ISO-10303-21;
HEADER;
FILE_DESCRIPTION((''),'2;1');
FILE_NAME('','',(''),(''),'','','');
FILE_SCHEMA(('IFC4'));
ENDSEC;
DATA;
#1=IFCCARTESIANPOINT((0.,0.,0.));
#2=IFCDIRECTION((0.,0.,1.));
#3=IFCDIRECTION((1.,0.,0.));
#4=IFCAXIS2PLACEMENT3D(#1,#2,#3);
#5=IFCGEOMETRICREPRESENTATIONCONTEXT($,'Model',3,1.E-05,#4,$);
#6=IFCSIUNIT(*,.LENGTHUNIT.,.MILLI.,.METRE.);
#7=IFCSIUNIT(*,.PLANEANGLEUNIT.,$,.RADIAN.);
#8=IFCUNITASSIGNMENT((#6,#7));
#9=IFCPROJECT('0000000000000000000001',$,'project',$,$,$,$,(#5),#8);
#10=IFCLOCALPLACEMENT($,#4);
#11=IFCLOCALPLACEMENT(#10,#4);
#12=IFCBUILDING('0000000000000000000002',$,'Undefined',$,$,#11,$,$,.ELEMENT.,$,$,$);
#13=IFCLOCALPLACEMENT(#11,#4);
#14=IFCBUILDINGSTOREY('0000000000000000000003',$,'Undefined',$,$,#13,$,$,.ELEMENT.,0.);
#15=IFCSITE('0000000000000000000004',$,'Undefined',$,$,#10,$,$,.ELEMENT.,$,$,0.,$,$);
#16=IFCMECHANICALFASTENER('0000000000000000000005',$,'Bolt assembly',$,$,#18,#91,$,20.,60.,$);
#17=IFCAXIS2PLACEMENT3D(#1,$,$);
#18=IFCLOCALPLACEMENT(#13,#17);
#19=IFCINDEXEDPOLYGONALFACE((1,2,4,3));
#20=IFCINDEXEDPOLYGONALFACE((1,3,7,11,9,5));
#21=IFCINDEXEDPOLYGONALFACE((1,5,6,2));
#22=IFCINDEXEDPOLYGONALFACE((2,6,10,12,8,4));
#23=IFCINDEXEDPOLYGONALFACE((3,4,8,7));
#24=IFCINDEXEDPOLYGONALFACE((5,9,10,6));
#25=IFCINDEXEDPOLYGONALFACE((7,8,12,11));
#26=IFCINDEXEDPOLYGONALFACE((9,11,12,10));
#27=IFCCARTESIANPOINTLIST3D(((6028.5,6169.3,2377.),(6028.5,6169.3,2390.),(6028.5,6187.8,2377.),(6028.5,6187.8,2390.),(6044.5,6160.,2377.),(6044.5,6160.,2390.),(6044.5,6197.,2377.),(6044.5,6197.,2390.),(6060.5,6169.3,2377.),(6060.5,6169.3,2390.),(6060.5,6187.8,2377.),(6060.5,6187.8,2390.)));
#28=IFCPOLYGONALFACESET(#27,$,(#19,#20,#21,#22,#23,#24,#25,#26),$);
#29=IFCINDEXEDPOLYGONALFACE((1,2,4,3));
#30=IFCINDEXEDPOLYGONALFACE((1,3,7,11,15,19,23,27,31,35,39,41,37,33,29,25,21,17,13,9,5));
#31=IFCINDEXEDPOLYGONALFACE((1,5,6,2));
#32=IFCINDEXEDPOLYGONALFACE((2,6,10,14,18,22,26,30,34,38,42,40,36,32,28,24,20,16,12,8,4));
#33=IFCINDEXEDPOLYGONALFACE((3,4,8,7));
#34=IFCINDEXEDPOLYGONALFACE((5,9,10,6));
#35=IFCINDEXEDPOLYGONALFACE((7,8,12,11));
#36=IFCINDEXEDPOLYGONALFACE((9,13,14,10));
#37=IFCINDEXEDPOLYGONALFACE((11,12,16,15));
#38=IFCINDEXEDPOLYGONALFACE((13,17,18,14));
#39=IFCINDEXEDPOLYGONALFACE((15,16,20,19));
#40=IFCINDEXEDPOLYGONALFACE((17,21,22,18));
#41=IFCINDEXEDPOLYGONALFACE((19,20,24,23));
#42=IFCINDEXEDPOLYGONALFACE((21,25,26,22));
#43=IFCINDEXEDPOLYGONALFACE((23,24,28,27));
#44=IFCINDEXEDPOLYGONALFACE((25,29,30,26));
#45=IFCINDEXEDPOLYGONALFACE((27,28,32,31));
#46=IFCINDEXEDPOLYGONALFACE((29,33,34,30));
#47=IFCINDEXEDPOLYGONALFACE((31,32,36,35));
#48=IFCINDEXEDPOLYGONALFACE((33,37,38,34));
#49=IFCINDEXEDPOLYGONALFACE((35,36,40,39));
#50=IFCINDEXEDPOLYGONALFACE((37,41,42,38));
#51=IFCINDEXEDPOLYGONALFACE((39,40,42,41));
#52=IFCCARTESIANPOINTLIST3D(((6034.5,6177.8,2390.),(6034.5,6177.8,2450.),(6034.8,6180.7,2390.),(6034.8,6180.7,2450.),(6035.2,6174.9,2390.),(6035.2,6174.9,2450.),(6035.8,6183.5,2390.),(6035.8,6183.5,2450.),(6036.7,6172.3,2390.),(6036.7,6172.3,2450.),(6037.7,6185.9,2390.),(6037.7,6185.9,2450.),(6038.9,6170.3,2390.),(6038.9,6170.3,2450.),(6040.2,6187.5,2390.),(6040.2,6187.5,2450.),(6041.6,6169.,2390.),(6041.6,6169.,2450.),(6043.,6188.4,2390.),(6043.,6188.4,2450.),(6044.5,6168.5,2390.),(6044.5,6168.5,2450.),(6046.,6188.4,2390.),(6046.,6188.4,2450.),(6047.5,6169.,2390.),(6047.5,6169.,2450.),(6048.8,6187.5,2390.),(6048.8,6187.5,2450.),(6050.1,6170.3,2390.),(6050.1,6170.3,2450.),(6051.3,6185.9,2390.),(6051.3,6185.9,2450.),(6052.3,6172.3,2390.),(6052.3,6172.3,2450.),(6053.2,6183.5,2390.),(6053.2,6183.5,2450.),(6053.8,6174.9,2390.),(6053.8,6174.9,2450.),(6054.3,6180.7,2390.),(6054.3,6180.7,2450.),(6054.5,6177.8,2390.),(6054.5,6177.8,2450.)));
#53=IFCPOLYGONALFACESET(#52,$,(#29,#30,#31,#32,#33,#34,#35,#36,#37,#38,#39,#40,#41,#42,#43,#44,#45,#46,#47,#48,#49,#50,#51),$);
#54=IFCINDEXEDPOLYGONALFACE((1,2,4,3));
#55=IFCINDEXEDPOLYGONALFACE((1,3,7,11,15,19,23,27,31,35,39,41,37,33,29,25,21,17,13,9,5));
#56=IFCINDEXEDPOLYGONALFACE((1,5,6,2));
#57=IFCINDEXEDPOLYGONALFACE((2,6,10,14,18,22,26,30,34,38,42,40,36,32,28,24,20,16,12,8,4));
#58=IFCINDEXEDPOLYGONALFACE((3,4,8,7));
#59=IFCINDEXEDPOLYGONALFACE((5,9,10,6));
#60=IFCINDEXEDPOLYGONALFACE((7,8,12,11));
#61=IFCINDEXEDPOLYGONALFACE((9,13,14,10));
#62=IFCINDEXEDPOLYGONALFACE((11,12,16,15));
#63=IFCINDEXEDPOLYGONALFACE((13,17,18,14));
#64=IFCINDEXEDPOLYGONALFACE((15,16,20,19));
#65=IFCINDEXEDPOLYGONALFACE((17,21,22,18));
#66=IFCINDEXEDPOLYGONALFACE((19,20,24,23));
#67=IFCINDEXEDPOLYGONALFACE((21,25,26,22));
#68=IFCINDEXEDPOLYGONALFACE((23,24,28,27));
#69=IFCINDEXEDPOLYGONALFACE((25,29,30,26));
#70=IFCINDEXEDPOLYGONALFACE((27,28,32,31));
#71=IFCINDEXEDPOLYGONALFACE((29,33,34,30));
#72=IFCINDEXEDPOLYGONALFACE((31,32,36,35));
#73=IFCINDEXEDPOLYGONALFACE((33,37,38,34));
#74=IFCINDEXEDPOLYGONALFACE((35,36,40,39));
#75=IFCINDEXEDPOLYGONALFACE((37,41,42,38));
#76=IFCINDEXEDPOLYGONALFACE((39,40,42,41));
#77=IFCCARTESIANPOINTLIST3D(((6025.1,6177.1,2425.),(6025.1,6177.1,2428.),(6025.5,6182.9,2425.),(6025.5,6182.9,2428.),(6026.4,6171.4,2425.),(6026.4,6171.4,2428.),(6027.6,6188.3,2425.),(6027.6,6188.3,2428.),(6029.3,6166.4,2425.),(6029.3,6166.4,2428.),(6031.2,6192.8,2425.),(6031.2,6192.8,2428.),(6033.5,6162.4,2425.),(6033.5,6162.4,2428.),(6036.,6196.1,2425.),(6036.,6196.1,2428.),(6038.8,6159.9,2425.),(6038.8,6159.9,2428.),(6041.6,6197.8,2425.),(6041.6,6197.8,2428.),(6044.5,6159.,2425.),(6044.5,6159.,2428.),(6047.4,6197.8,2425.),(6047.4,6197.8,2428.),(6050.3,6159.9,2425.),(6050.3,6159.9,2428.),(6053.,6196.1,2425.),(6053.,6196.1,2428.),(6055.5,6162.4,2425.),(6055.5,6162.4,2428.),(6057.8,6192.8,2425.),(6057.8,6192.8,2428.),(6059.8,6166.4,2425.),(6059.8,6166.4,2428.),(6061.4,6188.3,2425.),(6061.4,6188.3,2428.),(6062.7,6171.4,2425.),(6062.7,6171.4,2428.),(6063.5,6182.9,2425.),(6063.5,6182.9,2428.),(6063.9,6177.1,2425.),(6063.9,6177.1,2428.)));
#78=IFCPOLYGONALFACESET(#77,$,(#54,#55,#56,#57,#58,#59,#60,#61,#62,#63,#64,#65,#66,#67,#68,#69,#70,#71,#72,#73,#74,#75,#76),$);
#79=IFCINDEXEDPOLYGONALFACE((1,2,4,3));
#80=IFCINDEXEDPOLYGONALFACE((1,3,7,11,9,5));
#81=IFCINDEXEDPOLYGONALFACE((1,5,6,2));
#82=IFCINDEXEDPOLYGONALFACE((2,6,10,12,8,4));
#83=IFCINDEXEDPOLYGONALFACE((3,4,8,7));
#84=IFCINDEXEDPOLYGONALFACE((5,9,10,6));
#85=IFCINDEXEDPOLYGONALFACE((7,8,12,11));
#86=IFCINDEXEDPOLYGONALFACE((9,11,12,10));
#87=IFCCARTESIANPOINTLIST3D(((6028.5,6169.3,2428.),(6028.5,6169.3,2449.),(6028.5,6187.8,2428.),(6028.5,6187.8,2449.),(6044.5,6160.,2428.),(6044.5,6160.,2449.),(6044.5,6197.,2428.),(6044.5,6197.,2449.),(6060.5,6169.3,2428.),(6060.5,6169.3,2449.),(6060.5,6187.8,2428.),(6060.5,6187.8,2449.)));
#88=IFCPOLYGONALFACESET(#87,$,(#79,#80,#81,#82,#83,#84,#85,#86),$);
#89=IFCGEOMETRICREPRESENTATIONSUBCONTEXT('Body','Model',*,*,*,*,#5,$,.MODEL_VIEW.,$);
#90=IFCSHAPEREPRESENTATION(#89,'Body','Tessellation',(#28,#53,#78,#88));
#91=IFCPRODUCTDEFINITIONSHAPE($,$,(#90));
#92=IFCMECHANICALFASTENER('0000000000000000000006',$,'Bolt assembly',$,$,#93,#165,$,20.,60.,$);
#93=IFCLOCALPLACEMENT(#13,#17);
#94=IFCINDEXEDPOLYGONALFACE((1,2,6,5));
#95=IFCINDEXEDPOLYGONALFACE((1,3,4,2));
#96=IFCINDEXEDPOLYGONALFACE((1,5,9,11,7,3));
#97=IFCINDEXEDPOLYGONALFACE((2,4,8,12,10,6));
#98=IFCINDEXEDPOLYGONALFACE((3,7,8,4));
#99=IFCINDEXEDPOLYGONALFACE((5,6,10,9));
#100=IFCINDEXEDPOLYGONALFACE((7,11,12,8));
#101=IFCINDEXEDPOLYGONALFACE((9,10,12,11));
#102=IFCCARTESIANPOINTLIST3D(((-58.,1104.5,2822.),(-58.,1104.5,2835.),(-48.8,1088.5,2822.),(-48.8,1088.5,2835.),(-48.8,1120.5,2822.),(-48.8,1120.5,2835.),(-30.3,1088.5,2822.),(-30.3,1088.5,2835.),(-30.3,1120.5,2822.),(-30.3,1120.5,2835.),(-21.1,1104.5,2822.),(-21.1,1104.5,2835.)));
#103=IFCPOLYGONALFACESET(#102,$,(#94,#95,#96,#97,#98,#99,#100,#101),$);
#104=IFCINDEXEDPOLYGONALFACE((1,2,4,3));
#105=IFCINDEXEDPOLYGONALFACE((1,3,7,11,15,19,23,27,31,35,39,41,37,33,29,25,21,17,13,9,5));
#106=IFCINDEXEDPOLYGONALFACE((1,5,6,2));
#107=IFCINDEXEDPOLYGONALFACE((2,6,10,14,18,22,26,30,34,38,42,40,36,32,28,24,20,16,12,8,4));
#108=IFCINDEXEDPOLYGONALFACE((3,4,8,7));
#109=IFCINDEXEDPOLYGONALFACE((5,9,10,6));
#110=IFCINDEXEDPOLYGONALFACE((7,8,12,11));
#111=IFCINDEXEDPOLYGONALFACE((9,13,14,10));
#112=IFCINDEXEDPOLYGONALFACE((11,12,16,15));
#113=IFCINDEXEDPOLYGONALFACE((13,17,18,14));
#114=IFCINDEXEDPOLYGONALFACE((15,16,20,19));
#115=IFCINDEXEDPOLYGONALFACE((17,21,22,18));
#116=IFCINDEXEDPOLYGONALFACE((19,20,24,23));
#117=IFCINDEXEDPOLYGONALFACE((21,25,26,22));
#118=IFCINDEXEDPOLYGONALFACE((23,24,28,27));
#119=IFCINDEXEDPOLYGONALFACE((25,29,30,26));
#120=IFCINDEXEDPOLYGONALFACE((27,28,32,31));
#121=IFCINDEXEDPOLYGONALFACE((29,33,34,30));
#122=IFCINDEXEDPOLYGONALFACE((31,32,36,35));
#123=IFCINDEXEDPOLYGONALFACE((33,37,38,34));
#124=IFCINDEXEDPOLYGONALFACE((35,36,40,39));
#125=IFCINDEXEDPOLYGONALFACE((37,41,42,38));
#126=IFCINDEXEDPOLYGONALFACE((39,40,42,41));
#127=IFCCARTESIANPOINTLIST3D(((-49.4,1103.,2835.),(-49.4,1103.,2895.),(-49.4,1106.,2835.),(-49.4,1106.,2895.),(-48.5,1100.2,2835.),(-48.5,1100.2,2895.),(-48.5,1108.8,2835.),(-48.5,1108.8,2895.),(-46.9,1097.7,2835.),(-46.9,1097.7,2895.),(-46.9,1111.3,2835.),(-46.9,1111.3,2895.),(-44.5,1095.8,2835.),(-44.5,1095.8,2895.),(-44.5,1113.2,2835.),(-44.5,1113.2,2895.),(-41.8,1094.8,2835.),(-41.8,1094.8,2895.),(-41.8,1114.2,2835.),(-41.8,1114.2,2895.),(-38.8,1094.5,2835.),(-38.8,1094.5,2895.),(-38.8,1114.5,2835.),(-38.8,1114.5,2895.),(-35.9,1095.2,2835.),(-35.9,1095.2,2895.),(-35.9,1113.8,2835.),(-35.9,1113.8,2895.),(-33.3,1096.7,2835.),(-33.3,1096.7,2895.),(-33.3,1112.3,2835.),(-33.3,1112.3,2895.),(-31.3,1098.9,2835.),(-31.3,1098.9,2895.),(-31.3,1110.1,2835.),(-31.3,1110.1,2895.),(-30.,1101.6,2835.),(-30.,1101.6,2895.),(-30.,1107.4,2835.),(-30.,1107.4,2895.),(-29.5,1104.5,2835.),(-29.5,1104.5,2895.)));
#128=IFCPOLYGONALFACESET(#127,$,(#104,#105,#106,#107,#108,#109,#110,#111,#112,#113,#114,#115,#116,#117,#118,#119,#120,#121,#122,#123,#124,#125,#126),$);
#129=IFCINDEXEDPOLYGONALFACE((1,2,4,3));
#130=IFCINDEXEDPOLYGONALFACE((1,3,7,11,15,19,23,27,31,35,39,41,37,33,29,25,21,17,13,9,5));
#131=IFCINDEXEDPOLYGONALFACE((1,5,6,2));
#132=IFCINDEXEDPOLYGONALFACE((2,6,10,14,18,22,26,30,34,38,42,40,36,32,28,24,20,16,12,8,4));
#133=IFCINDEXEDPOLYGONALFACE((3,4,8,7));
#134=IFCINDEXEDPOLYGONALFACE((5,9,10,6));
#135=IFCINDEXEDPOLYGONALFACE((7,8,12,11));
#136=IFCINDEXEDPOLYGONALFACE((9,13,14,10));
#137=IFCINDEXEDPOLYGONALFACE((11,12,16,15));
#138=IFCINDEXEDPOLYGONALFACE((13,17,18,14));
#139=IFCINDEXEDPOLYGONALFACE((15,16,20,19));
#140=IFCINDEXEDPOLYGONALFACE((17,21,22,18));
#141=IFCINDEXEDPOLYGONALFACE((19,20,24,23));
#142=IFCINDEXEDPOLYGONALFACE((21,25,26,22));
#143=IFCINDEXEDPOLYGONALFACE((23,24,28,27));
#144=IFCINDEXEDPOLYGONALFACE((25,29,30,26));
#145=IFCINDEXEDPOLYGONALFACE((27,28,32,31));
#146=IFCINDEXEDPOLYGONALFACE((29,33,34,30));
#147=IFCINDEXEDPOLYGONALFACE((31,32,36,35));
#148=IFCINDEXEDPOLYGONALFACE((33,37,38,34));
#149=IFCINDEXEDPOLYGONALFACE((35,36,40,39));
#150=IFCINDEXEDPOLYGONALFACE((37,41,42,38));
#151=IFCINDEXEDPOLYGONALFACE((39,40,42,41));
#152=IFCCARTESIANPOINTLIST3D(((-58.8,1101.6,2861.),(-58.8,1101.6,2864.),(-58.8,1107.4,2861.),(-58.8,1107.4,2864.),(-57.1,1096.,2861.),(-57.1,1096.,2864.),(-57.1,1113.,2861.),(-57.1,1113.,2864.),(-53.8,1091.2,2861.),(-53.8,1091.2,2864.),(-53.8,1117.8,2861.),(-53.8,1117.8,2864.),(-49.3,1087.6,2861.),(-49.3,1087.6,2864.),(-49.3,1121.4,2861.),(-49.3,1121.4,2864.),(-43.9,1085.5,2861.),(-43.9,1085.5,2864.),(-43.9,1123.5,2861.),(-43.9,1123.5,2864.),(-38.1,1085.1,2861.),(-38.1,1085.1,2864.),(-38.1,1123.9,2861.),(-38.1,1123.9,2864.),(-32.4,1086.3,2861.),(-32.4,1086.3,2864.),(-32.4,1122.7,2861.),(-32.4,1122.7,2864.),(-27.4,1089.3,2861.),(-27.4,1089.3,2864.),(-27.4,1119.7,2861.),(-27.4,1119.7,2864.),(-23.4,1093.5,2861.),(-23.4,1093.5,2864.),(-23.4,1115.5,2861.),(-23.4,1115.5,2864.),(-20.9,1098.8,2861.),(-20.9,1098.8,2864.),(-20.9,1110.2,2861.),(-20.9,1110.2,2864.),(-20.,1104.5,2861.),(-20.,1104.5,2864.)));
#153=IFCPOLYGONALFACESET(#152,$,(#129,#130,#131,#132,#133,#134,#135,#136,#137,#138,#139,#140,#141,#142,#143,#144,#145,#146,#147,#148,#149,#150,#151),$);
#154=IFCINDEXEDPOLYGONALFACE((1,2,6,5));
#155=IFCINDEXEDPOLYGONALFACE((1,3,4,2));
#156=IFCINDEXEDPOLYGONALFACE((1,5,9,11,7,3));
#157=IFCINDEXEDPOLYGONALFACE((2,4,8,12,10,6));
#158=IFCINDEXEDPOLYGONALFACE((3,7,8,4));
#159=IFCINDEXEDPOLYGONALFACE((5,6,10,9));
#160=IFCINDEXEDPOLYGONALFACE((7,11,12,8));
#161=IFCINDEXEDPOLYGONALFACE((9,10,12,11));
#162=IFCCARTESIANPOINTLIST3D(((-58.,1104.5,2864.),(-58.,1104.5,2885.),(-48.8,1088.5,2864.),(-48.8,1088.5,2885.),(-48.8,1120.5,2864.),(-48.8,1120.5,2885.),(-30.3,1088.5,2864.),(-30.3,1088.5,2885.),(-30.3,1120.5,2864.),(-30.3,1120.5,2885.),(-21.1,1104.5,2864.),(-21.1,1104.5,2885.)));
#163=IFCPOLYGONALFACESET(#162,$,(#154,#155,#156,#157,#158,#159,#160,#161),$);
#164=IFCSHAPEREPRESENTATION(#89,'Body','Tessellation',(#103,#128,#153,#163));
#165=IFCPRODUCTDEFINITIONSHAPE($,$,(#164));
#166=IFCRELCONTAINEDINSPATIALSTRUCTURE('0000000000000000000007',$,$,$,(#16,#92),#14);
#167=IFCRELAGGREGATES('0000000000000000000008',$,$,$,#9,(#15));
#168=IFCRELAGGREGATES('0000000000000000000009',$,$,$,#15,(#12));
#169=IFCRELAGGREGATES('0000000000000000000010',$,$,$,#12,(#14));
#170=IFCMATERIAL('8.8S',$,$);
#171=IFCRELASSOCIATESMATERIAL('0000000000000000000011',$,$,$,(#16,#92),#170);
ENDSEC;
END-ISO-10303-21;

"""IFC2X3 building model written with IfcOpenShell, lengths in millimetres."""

from ifc_helpers import new_model, si_unit, frame, origin_with_axes, origin_2d_with_axis, place, context, subcontext, project, spatial, polyline, circle, outline, extrude, source, transform, mapped, material, element, save


model = new_model("IFC2X3")

# Units and contexts
model_context = context("Model", 3, precision=1e-05, world=origin_with_axes())
body_context = subcontext(model_context, "Body", "Model", "MODEL_VIEW")
ifc_project = project(units=[si_unit("LENGTHUNIT", "METRE", prefix="MILLI"), si_unit("PLANEANGLEUNIT", "RADIAN")], contexts=[model_context])

# Site, building, storey
site_placement = place(None, origin_with_axes())
site = spatial("IfcSite", under=ifc_project, at=site_placement, Name="Undefined", CompositionType="ELEMENT", RefElevation=0.0)
building_placement = place(site_placement, origin_with_axes())
building = spatial("IfcBuilding", under=site, at=building_placement, Name="Undefined", CompositionType="ELEMENT")
storey_placement = place(building_placement, origin_with_axes())
storey = spatial("IfcBuildingStorey", under=building, at=storey_placement, Name="Undefined", CompositionType="ELEMENT", Elevation=0.0)

# Mechanical fasteners
ifc_material_1 = material(Name="8.8S")
shared_shape_1 = source(origin_with_axes(), body_context, "Body", "SweptSolid", [
    extrude(outline(polyline([(18.5, 0.0), (9.2, 16.0), (-9.2, 16.0), (-18.5, 0.0), (-9.2, -16.0), (9.2, -16.0), (18.5, 0.0)])), frame((0.0, -8.0, 0.0), z_axis=(0.0, 1.0, 0.0), x_axis=(1.0, 0.0, 0.0)), (0.0, 0.0, 1.0), 13.0),
    extrude(circle(Radius=10.0, at=origin_2d_with_axis()), frame((0.0, 5.0, 0.0), z_axis=(0.0, 1.0, 0.0), x_axis=(1.0, 0.0, 0.0)), (0.0, 0.0, 1.0), 60.0),
    extrude(circle(Radius=19.5, at=origin_2d_with_axis()), frame((0.0, 40.0, 0.0), z_axis=(0.0, 1.0, 0.0), x_axis=(1.0, 0.0, 0.0)), (0.0, 0.0, 1.0), 3.0),
    extrude(outline(polyline([(18.5, 0.0), (9.2, 16.0), (-9.2, 16.0), (-18.5, 0.0), (-9.2, -16.0), (9.2, -16.0), (18.5, 0.0)])), frame((0.0, 43.0, 0.0), z_axis=(0.0, 1.0, 0.0), x_axis=(1.0, 0.0, 0.0)), (0.0, 0.0, 1.0), 21.0),
])
mechanical_fastener_placement = place(storey_placement, frame((6044.5, 6178.5, 2385.0), z_axis=(-1.0, 0.0, 0.0), x_axis=(0.0, -1.0, 0.000008)))
element("IfcMechanicalFastener", 1, at=mechanical_fastener_placement, inside=storey, material=ifc_material_1, Name="Bolt assembly", NominalDiameter=20.0, NominalLength=60.0, context=body_context, shape_type="MappedRepresentation", body=[
    mapped(shared_shape_1, transform((0.0, 0.0, 0.0))),
])
shared_shape_2 = source(origin_with_axes(), body_context, "Body", "SweptSolid", [
    extrude(outline(polyline([(18.5, 0.0), (9.2, 16.0), (-9.2, 16.0), (-18.5, 0.0), (-9.2, -16.0), (9.2, -16.0), (18.5, 0.0)])), frame((0.0, -23.0, 0.0), z_axis=(0.0, 1.0, 0.0), x_axis=(1.0, 0.0, 0.0)), (0.0, 0.0, 1.0), 13.0),
    extrude(circle(Radius=10.0, at=origin_2d_with_axis()), frame((0.0, -10.0, 0.0), z_axis=(0.0, 1.0, 0.0), x_axis=(1.0, 0.0, 0.0)), (0.0, 0.0, 1.0), 60.0),
    extrude(circle(Radius=19.5, at=origin_2d_with_axis()), frame((0.0, 16.0, 0.0), z_axis=(0.0, 1.0, 0.0), x_axis=(1.0, 0.0, 0.0)), (0.0, 0.0, 1.0), 3.0),
    extrude(outline(polyline([(18.5, 0.0), (9.2, 16.0), (-9.2, 16.0), (-18.5, 0.0), (-9.2, -16.0), (9.2, -16.0), (18.5, 0.0)])), frame((0.0, 19.0, 0.0), z_axis=(0.0, 1.0, 0.0), x_axis=(1.0, 0.0, 0.0)), (0.0, 0.0, 1.0), 21.0),
])
for number, where, z_axis, x_axis, name in (
    (2, (-39.5, 1104.5, 2845.0), (0.0, -1.0, 0.0), (1.0, 0.0, 0.0), "Bolt assembly"),
):
    element("IfcMechanicalFastener", number, at=place(storey_placement, frame(where, z_axis=z_axis, x_axis=x_axis)), inside=storey, material=ifc_material_1, Name=name, NominalDiameter=20.0, NominalLength=60.0, context=body_context, shape_type="MappedRepresentation", body=[
        mapped(shared_shape_2, transform((0.0, 0.0, 0.0))),
    ])

save(model, "model.ifc")
